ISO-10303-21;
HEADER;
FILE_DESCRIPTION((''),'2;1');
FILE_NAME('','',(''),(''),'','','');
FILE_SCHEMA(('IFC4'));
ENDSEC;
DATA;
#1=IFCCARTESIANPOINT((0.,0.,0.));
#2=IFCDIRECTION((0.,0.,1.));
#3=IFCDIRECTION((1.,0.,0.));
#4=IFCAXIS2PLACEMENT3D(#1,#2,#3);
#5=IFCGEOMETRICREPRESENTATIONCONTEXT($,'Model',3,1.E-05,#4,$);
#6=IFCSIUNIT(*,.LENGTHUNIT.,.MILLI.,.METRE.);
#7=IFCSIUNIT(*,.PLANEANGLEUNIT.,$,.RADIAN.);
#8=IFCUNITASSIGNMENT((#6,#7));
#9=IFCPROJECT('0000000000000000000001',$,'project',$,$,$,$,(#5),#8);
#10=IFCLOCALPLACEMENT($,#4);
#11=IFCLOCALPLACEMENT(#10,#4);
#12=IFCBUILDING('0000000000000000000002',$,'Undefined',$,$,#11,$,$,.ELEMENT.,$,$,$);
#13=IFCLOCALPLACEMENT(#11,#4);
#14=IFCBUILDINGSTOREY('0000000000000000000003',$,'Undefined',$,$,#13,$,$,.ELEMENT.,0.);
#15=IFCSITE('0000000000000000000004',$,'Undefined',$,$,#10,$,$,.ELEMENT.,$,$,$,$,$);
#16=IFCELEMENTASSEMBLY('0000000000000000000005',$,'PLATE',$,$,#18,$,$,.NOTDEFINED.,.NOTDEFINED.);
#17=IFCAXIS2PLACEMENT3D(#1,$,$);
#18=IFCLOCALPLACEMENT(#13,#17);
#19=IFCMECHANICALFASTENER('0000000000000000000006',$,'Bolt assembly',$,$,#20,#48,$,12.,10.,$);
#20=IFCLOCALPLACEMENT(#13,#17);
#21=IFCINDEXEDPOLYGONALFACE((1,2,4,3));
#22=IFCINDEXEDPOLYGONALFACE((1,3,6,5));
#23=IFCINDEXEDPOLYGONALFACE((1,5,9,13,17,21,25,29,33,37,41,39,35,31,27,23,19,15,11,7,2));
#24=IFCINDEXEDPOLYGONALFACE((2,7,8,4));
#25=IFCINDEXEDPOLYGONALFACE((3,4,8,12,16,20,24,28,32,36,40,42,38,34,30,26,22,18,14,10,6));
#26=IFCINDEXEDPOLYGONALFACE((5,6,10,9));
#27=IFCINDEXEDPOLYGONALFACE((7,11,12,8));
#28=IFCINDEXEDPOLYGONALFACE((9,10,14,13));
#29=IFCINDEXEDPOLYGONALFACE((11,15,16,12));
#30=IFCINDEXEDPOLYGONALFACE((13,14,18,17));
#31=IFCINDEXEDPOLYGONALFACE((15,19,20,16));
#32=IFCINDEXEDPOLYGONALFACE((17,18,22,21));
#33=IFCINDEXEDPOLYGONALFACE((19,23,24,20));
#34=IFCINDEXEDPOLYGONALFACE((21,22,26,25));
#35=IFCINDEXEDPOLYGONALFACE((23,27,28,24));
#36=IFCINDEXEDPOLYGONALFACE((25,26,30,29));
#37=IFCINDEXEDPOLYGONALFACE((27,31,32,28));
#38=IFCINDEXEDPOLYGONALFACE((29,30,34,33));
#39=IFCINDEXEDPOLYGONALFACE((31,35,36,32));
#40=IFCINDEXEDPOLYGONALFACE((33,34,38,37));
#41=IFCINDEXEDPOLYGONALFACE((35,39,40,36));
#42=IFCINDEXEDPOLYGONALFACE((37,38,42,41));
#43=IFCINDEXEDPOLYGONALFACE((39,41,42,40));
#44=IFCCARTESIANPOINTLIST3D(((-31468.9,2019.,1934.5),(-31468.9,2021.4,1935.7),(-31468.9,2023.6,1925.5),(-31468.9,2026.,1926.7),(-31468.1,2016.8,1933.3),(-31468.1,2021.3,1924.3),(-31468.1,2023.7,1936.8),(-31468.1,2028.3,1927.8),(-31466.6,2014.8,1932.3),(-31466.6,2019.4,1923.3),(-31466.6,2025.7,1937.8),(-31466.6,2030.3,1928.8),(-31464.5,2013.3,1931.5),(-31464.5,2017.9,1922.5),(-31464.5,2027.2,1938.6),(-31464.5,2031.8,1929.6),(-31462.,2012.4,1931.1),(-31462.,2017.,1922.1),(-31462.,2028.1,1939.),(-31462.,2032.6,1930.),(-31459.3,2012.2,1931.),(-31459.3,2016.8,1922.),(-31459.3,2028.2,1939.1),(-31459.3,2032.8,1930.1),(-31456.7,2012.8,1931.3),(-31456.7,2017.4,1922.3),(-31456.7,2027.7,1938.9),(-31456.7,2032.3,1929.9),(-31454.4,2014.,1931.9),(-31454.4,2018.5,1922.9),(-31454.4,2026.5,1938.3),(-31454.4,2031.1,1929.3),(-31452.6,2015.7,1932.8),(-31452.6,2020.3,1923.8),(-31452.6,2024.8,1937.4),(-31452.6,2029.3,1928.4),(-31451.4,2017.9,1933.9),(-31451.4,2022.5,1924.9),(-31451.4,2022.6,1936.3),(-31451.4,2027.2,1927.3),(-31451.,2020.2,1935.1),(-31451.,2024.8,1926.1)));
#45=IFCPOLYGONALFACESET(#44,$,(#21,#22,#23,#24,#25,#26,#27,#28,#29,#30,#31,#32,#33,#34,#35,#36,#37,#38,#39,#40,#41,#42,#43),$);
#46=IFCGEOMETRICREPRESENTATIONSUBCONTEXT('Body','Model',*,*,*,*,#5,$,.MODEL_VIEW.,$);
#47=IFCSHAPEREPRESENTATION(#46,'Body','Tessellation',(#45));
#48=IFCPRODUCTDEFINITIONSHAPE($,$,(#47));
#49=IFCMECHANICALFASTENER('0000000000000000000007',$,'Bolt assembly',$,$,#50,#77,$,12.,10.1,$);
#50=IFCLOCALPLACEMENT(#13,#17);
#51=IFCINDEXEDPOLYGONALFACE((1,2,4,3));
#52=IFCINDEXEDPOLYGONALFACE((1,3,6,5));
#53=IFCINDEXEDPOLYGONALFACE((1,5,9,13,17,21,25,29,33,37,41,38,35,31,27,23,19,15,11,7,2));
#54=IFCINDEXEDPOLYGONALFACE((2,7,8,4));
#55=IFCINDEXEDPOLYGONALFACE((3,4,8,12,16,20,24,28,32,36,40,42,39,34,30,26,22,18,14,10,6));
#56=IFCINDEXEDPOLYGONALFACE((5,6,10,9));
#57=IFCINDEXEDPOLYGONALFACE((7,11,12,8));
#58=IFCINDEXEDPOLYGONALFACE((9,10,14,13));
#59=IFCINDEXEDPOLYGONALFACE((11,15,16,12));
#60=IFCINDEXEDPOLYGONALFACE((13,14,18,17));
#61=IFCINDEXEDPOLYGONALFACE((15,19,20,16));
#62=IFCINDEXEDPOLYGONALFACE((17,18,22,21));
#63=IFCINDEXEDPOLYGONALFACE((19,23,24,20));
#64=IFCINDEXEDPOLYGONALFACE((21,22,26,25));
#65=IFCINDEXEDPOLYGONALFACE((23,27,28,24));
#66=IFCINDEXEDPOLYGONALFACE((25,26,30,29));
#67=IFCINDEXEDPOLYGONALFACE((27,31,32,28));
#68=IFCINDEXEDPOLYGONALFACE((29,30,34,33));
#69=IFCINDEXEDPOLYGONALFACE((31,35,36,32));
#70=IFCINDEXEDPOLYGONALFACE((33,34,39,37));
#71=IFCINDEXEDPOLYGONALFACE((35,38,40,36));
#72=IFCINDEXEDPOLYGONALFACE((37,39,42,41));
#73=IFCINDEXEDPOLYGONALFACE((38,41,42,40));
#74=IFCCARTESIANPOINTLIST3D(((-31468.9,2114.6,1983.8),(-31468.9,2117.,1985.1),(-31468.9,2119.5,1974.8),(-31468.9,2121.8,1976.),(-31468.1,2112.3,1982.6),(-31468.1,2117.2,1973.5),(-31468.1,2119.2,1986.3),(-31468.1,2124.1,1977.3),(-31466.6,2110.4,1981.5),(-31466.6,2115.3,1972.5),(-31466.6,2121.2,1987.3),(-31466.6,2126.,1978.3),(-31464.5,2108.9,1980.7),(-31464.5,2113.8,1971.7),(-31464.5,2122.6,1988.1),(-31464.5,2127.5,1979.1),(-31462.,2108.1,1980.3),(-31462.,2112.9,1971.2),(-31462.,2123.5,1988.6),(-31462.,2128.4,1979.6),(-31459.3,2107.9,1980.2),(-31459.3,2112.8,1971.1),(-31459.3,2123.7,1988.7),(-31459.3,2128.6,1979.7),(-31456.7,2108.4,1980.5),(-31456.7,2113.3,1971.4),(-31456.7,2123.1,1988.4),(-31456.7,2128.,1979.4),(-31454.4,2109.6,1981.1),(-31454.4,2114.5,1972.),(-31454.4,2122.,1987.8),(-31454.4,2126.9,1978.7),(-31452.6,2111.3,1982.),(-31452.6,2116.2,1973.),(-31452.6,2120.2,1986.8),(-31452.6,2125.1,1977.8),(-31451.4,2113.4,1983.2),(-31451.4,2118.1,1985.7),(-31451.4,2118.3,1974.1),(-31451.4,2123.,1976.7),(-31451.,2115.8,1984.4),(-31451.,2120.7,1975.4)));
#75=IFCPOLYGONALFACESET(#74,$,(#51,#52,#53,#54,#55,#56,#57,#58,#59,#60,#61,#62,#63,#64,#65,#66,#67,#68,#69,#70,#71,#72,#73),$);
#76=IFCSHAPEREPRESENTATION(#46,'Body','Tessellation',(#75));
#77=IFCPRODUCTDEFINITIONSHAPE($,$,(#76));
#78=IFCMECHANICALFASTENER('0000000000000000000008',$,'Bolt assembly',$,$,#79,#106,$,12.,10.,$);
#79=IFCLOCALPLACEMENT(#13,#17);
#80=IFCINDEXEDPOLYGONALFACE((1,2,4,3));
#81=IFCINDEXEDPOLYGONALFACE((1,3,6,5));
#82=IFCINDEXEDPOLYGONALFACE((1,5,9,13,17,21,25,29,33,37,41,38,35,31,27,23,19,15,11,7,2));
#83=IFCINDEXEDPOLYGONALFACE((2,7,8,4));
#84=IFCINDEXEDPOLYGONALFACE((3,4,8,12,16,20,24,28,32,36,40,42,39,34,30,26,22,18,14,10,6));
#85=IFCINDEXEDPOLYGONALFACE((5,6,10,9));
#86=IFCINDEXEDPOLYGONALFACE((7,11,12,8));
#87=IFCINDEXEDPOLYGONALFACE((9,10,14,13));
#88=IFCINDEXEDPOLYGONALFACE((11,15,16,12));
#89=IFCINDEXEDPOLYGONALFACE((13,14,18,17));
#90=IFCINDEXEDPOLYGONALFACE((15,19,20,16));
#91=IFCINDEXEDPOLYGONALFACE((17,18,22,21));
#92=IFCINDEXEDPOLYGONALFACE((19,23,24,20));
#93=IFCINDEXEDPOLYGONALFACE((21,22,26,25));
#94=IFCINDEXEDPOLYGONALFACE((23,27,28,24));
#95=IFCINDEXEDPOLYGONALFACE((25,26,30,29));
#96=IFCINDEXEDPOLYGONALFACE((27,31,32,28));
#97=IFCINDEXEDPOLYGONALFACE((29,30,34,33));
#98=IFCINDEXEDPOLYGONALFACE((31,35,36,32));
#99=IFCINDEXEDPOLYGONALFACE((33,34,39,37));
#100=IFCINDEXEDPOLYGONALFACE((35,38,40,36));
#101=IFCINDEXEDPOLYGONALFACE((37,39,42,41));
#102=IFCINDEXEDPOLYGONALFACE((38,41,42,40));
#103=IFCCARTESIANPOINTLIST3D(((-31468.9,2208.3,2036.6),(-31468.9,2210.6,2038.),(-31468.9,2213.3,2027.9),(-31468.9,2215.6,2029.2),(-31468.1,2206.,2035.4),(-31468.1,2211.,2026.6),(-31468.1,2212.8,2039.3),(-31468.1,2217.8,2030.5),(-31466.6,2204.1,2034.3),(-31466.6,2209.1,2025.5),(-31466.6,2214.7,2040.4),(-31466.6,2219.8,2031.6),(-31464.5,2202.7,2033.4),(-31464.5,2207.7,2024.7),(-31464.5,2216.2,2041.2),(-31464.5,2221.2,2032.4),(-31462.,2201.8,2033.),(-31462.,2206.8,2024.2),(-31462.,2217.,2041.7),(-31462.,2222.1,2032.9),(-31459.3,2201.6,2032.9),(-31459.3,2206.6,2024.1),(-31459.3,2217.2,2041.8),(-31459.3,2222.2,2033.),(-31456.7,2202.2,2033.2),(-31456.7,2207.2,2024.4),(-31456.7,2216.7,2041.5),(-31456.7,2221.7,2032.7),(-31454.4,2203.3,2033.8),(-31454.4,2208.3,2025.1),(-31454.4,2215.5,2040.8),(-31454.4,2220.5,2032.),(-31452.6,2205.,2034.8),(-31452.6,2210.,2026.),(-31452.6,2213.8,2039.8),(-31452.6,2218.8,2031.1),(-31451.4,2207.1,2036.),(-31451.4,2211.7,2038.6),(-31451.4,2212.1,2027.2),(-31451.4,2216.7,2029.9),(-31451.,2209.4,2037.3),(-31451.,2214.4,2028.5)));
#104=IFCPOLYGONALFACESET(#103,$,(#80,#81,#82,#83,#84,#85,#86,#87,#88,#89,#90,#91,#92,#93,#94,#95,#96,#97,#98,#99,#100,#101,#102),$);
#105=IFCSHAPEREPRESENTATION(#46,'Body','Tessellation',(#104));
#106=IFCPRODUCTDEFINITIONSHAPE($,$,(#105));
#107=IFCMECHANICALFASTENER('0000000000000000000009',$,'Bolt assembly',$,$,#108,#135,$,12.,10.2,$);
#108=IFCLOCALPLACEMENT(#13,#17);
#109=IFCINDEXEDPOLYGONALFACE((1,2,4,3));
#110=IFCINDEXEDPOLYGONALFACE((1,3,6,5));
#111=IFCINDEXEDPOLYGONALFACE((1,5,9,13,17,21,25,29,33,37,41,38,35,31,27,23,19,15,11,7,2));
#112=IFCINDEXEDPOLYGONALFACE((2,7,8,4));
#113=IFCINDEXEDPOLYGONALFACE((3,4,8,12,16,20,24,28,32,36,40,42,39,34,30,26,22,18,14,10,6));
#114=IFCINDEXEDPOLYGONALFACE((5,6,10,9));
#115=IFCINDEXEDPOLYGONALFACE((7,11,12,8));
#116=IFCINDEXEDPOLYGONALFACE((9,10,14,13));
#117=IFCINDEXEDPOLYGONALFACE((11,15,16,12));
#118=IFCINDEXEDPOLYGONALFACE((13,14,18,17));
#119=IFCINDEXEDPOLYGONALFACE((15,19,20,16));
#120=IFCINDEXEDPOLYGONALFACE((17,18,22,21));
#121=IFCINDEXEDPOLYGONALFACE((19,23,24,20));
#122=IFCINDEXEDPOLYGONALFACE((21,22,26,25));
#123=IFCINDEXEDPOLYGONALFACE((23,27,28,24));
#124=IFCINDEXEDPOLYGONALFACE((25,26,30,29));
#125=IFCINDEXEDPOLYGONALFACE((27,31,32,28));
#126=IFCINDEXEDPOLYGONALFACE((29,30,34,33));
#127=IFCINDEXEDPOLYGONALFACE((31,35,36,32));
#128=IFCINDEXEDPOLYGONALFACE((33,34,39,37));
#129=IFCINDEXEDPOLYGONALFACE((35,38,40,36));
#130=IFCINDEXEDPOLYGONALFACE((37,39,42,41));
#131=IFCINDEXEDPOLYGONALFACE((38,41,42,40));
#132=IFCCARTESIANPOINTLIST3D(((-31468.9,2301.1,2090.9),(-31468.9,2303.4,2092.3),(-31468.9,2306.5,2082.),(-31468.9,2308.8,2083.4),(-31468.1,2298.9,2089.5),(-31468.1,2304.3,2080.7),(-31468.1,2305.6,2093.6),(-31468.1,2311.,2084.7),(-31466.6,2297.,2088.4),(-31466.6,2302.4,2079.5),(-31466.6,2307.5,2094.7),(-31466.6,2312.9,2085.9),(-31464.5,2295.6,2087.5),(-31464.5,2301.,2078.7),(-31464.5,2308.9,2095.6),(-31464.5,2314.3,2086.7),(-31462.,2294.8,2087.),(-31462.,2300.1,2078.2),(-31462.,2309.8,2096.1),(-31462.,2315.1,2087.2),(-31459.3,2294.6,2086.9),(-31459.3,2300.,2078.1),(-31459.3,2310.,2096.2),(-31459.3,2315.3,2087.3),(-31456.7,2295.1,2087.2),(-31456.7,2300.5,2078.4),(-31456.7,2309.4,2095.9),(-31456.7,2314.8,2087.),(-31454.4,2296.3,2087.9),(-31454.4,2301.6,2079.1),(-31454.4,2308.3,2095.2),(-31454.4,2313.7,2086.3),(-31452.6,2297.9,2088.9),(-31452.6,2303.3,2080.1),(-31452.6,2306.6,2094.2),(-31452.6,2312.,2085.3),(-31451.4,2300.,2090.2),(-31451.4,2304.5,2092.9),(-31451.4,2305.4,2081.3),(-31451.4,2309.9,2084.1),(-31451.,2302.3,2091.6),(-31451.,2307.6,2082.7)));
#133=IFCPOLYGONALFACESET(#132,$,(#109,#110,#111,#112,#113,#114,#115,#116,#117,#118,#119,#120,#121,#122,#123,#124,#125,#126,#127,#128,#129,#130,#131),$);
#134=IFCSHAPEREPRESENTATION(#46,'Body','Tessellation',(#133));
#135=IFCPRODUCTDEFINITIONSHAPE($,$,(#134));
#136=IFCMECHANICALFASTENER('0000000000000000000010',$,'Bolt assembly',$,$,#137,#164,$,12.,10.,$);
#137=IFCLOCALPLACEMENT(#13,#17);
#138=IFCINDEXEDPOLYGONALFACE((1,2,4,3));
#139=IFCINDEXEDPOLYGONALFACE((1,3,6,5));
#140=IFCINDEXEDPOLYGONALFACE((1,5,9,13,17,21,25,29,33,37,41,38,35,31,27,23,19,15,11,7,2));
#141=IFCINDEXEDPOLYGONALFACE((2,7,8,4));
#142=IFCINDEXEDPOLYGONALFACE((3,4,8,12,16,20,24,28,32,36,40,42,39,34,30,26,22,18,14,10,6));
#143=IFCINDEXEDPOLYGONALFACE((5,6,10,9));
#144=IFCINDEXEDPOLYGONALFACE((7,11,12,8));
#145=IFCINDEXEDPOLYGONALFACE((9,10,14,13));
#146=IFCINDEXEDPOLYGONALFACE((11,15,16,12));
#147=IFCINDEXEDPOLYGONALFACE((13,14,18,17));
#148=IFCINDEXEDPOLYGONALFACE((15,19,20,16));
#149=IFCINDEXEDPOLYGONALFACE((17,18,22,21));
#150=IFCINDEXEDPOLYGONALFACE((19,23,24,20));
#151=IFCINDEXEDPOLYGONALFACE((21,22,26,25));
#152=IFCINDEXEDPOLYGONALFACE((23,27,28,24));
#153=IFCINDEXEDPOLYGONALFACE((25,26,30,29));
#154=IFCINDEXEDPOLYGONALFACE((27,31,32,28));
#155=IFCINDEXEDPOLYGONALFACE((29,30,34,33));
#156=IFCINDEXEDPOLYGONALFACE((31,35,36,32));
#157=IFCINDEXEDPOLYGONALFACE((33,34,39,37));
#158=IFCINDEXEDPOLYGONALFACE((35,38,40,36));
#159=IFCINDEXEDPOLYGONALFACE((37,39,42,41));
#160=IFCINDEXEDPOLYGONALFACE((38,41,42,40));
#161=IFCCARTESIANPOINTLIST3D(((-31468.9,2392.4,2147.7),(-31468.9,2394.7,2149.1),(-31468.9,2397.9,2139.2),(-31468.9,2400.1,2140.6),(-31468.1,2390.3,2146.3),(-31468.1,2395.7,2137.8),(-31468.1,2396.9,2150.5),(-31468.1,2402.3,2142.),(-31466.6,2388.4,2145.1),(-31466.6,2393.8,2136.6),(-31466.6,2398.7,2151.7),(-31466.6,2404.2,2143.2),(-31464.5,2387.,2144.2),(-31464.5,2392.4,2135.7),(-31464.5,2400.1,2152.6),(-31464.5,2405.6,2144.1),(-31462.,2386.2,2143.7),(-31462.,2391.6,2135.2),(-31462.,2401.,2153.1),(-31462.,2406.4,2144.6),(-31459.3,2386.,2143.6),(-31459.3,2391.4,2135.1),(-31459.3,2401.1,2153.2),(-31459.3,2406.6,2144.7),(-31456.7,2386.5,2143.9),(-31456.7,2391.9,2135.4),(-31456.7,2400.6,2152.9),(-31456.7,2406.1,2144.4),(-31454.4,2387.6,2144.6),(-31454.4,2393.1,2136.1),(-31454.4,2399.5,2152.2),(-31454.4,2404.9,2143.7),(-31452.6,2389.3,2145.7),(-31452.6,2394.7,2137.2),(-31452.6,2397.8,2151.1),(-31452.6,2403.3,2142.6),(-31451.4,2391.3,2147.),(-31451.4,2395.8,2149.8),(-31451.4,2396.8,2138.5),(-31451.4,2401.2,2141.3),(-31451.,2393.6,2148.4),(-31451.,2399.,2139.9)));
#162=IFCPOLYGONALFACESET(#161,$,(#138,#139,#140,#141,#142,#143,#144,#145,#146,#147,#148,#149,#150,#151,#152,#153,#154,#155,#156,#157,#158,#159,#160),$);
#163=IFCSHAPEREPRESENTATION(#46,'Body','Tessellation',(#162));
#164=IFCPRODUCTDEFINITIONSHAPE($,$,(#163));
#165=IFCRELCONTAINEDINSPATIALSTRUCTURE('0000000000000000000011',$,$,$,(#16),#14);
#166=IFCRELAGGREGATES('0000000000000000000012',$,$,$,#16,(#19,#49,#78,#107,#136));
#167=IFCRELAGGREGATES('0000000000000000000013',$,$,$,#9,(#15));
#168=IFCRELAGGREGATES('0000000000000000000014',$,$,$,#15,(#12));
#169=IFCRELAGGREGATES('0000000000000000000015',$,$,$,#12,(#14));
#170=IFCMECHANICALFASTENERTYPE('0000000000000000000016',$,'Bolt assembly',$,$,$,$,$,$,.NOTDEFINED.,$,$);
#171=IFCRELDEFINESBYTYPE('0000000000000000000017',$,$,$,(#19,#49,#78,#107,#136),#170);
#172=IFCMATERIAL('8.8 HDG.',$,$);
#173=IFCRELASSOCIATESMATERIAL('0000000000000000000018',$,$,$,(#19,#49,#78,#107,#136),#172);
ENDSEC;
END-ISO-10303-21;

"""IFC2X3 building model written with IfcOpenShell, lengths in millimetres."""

from ifc_helpers import new_model, si_unit, frame, origin_with_axes, origin_2d_with_axis, place, context, subcontext, project, spatial, circle, extrude, source, transform, mapped, material, type_object, element, aggregate, save


model = new_model("IFC2X3")

# Units and contexts
model_context = context("Model", 3, precision=1e-05, world=origin_with_axes())
body_context = subcontext(model_context, "Body", "Model", "MODEL_VIEW")
ifc_project = project(units=[si_unit("LENGTHUNIT", "METRE", prefix="MILLI"), si_unit("PLANEANGLEUNIT", "RADIAN")], contexts=[model_context])

# Site, building, storey
site_placement = place(None, origin_with_axes())
site = spatial("IfcSite", under=ifc_project, at=site_placement, Name="Undefined", CompositionType="ELEMENT")
building_placement = place(site_placement, origin_with_axes())
building = spatial("IfcBuilding", under=site, at=building_placement, Name="Undefined", CompositionType="ELEMENT")
storey_placement = place(building_placement, origin_with_axes())
storey = spatial("IfcBuildingStorey", under=building, at=storey_placement, Name="Undefined", CompositionType="ELEMENT", Elevation=0.0)

# Element assembly, mechanical fasteners
assembly_placement = place(storey_placement, origin_with_axes())
assembly = element("IfcElementAssembly", 1, at=assembly_placement, inside=storey, Name="PLATE", AssemblyPlace="NOTDEFINED", PredefinedType="NOTDEFINED")
ifc_material_1 = material(Name="8.8 HDG.")
mechanical_fastener_type = type_object("IfcMechanicalFastenerType", Name="Bolt assembly")
shared_shape_1 = source(origin_with_axes(), body_context, "Body", "SweptSolid", [
    extrude(circle(Radius=9.0, at=origin_2d_with_axis()), frame((0.0, 0.9, 0.0), z_axis=(0.0, 1.0, 0.0), x_axis=(1.0, 0.0, 0.0)), (0.0, 0.0, 1.0), 10.1),
])
mechanical_fastener_1_placement = place(assembly_placement, frame((-31460.0, 2025.2, 1925.3), z_axis=(0.000001, -0.891006, -0.453991), x_axis=(1.0, 0.000001, 0.0)))
mechanical_fastener_1 = element("IfcMechanicalFastener", 2, at=mechanical_fastener_1_placement, type_object=mechanical_fastener_type, material=ifc_material_1, Name="Bolt assembly", NominalDiameter=12.0, NominalLength=10.0, context=body_context, shape_type="MappedRepresentation", body=[
    mapped(shared_shape_1, transform((0.0, 0.0, 0.0))),
])
shared_shape_2 = source(origin_with_axes(), body_context, "Body", "SweptSolid", [
    extrude(circle(Radius=9.0, at=origin_2d_with_axis()), frame((0.0, 0.0, 0.0), z_axis=(0.0, 1.0, 0.0), x_axis=(1.0, 0.0, 0.0)), (0.0, 0.0, 1.0), 10.3),
])
mechanical_fastener_2_placement = place(assembly_placement, frame((-31460.0, 2120.7, 1975.4), z_axis=(0.000001, -0.879776, -0.475388), x_axis=(1.0, 0.000001, 0.0)))
mechanical_fastener_2 = element("IfcMechanicalFastener", 3, at=mechanical_fastener_2_placement, type_object=mechanical_fastener_type, material=ifc_material_1, Name="Bolt assembly", NominalDiameter=12.0, NominalLength=10.1, context=body_context, shape_type="MappedRepresentation", body=[
    mapped(shared_shape_2, transform((0.0, 0.0, 0.0))),
])
shared_shape_3 = source(origin_with_axes(), body_context, "Body", "SweptSolid", [
    extrude(circle(Radius=9.0, at=origin_2d_with_axis()), frame((0.0, 0.9, 0.0), z_axis=(0.0, 1.0, 0.0), x_axis=(1.0, 0.0, 0.0)), (0.0, 0.0, 1.0), 10.1),
])
mechanical_fastener_3_placement = place(assembly_placement, frame((-31460.0, 2214.9, 2027.8), z_axis=(0.000001, -0.868032, -0.496508), x_axis=(1.0, 0.000001, 0.0)))
mechanical_fastener_3 = element("IfcMechanicalFastener", 4, at=mechanical_fastener_3_placement, type_object=mechanical_fastener_type, material=ifc_material_1, Name="Bolt assembly", NominalDiameter=12.0, NominalLength=10.0, context=body_context, shape_type="MappedRepresentation", body=[
    mapped(shared_shape_3, transform((0.0, 0.0, 0.0))),
])
shared_shape_4 = source(origin_with_axes(), body_context, "Body", "SweptSolid", [
    extrude(circle(Radius=9.0, at=origin_2d_with_axis()), frame((0.0, 0.3, 0.0), z_axis=(0.0, 1.0, 0.0), x_axis=(1.0, 0.0, 0.0)), (0.0, 0.0, 1.0), 10.4),
])
mechanical_fastener_4_placement = place(assembly_placement, frame((-31460.0, 2307.8, 2082.4), z_axis=(0.000001, -0.855781, -0.517338), x_axis=(1.0, 0.000001, 0.0)))
mechanical_fastener_4 = element("IfcMechanicalFastener", 5, at=mechanical_fastener_4_placement, type_object=mechanical_fastener_type, material=ifc_material_1, Name="Bolt assembly", NominalDiameter=12.0, NominalLength=10.2, context=body_context, shape_type="MappedRepresentation", body=[
    mapped(shared_shape_4, transform((0.0, 0.0, 0.0))),
])
shared_shape_5 = source(origin_with_axes(), body_context, "Body", "SweptSolid", [
    extrude(circle(Radius=9.0, at=origin_2d_with_axis()), frame((0.0, 0.7, 0.0), z_axis=(0.0, 1.0, 0.0), x_axis=(1.0, 0.0, 0.0)), (0.0, 0.0, 1.0), 10.1),
])
mechanical_fastener_5_placement = place(assembly_placement, frame((-31460.0, 2399.4, 2139.3), z_axis=(0.000001, -0.843031, -0.537866), x_axis=(1.0, 0.000001, 0.0)))
mechanical_fastener_5 = element("IfcMechanicalFastener", 6, at=mechanical_fastener_5_placement, type_object=mechanical_fastener_type, material=ifc_material_1, Name="Bolt assembly", NominalDiameter=12.0, NominalLength=10.0, context=body_context, shape_type="MappedRepresentation", body=[
    mapped(shared_shape_5, transform((0.0, 0.0, 0.0))),
])
aggregate(assembly, [mechanical_fastener_1, mechanical_fastener_2, mechanical_fastener_3, mechanical_fastener_4, mechanical_fastener_5])

save(model, "model.ifc")
